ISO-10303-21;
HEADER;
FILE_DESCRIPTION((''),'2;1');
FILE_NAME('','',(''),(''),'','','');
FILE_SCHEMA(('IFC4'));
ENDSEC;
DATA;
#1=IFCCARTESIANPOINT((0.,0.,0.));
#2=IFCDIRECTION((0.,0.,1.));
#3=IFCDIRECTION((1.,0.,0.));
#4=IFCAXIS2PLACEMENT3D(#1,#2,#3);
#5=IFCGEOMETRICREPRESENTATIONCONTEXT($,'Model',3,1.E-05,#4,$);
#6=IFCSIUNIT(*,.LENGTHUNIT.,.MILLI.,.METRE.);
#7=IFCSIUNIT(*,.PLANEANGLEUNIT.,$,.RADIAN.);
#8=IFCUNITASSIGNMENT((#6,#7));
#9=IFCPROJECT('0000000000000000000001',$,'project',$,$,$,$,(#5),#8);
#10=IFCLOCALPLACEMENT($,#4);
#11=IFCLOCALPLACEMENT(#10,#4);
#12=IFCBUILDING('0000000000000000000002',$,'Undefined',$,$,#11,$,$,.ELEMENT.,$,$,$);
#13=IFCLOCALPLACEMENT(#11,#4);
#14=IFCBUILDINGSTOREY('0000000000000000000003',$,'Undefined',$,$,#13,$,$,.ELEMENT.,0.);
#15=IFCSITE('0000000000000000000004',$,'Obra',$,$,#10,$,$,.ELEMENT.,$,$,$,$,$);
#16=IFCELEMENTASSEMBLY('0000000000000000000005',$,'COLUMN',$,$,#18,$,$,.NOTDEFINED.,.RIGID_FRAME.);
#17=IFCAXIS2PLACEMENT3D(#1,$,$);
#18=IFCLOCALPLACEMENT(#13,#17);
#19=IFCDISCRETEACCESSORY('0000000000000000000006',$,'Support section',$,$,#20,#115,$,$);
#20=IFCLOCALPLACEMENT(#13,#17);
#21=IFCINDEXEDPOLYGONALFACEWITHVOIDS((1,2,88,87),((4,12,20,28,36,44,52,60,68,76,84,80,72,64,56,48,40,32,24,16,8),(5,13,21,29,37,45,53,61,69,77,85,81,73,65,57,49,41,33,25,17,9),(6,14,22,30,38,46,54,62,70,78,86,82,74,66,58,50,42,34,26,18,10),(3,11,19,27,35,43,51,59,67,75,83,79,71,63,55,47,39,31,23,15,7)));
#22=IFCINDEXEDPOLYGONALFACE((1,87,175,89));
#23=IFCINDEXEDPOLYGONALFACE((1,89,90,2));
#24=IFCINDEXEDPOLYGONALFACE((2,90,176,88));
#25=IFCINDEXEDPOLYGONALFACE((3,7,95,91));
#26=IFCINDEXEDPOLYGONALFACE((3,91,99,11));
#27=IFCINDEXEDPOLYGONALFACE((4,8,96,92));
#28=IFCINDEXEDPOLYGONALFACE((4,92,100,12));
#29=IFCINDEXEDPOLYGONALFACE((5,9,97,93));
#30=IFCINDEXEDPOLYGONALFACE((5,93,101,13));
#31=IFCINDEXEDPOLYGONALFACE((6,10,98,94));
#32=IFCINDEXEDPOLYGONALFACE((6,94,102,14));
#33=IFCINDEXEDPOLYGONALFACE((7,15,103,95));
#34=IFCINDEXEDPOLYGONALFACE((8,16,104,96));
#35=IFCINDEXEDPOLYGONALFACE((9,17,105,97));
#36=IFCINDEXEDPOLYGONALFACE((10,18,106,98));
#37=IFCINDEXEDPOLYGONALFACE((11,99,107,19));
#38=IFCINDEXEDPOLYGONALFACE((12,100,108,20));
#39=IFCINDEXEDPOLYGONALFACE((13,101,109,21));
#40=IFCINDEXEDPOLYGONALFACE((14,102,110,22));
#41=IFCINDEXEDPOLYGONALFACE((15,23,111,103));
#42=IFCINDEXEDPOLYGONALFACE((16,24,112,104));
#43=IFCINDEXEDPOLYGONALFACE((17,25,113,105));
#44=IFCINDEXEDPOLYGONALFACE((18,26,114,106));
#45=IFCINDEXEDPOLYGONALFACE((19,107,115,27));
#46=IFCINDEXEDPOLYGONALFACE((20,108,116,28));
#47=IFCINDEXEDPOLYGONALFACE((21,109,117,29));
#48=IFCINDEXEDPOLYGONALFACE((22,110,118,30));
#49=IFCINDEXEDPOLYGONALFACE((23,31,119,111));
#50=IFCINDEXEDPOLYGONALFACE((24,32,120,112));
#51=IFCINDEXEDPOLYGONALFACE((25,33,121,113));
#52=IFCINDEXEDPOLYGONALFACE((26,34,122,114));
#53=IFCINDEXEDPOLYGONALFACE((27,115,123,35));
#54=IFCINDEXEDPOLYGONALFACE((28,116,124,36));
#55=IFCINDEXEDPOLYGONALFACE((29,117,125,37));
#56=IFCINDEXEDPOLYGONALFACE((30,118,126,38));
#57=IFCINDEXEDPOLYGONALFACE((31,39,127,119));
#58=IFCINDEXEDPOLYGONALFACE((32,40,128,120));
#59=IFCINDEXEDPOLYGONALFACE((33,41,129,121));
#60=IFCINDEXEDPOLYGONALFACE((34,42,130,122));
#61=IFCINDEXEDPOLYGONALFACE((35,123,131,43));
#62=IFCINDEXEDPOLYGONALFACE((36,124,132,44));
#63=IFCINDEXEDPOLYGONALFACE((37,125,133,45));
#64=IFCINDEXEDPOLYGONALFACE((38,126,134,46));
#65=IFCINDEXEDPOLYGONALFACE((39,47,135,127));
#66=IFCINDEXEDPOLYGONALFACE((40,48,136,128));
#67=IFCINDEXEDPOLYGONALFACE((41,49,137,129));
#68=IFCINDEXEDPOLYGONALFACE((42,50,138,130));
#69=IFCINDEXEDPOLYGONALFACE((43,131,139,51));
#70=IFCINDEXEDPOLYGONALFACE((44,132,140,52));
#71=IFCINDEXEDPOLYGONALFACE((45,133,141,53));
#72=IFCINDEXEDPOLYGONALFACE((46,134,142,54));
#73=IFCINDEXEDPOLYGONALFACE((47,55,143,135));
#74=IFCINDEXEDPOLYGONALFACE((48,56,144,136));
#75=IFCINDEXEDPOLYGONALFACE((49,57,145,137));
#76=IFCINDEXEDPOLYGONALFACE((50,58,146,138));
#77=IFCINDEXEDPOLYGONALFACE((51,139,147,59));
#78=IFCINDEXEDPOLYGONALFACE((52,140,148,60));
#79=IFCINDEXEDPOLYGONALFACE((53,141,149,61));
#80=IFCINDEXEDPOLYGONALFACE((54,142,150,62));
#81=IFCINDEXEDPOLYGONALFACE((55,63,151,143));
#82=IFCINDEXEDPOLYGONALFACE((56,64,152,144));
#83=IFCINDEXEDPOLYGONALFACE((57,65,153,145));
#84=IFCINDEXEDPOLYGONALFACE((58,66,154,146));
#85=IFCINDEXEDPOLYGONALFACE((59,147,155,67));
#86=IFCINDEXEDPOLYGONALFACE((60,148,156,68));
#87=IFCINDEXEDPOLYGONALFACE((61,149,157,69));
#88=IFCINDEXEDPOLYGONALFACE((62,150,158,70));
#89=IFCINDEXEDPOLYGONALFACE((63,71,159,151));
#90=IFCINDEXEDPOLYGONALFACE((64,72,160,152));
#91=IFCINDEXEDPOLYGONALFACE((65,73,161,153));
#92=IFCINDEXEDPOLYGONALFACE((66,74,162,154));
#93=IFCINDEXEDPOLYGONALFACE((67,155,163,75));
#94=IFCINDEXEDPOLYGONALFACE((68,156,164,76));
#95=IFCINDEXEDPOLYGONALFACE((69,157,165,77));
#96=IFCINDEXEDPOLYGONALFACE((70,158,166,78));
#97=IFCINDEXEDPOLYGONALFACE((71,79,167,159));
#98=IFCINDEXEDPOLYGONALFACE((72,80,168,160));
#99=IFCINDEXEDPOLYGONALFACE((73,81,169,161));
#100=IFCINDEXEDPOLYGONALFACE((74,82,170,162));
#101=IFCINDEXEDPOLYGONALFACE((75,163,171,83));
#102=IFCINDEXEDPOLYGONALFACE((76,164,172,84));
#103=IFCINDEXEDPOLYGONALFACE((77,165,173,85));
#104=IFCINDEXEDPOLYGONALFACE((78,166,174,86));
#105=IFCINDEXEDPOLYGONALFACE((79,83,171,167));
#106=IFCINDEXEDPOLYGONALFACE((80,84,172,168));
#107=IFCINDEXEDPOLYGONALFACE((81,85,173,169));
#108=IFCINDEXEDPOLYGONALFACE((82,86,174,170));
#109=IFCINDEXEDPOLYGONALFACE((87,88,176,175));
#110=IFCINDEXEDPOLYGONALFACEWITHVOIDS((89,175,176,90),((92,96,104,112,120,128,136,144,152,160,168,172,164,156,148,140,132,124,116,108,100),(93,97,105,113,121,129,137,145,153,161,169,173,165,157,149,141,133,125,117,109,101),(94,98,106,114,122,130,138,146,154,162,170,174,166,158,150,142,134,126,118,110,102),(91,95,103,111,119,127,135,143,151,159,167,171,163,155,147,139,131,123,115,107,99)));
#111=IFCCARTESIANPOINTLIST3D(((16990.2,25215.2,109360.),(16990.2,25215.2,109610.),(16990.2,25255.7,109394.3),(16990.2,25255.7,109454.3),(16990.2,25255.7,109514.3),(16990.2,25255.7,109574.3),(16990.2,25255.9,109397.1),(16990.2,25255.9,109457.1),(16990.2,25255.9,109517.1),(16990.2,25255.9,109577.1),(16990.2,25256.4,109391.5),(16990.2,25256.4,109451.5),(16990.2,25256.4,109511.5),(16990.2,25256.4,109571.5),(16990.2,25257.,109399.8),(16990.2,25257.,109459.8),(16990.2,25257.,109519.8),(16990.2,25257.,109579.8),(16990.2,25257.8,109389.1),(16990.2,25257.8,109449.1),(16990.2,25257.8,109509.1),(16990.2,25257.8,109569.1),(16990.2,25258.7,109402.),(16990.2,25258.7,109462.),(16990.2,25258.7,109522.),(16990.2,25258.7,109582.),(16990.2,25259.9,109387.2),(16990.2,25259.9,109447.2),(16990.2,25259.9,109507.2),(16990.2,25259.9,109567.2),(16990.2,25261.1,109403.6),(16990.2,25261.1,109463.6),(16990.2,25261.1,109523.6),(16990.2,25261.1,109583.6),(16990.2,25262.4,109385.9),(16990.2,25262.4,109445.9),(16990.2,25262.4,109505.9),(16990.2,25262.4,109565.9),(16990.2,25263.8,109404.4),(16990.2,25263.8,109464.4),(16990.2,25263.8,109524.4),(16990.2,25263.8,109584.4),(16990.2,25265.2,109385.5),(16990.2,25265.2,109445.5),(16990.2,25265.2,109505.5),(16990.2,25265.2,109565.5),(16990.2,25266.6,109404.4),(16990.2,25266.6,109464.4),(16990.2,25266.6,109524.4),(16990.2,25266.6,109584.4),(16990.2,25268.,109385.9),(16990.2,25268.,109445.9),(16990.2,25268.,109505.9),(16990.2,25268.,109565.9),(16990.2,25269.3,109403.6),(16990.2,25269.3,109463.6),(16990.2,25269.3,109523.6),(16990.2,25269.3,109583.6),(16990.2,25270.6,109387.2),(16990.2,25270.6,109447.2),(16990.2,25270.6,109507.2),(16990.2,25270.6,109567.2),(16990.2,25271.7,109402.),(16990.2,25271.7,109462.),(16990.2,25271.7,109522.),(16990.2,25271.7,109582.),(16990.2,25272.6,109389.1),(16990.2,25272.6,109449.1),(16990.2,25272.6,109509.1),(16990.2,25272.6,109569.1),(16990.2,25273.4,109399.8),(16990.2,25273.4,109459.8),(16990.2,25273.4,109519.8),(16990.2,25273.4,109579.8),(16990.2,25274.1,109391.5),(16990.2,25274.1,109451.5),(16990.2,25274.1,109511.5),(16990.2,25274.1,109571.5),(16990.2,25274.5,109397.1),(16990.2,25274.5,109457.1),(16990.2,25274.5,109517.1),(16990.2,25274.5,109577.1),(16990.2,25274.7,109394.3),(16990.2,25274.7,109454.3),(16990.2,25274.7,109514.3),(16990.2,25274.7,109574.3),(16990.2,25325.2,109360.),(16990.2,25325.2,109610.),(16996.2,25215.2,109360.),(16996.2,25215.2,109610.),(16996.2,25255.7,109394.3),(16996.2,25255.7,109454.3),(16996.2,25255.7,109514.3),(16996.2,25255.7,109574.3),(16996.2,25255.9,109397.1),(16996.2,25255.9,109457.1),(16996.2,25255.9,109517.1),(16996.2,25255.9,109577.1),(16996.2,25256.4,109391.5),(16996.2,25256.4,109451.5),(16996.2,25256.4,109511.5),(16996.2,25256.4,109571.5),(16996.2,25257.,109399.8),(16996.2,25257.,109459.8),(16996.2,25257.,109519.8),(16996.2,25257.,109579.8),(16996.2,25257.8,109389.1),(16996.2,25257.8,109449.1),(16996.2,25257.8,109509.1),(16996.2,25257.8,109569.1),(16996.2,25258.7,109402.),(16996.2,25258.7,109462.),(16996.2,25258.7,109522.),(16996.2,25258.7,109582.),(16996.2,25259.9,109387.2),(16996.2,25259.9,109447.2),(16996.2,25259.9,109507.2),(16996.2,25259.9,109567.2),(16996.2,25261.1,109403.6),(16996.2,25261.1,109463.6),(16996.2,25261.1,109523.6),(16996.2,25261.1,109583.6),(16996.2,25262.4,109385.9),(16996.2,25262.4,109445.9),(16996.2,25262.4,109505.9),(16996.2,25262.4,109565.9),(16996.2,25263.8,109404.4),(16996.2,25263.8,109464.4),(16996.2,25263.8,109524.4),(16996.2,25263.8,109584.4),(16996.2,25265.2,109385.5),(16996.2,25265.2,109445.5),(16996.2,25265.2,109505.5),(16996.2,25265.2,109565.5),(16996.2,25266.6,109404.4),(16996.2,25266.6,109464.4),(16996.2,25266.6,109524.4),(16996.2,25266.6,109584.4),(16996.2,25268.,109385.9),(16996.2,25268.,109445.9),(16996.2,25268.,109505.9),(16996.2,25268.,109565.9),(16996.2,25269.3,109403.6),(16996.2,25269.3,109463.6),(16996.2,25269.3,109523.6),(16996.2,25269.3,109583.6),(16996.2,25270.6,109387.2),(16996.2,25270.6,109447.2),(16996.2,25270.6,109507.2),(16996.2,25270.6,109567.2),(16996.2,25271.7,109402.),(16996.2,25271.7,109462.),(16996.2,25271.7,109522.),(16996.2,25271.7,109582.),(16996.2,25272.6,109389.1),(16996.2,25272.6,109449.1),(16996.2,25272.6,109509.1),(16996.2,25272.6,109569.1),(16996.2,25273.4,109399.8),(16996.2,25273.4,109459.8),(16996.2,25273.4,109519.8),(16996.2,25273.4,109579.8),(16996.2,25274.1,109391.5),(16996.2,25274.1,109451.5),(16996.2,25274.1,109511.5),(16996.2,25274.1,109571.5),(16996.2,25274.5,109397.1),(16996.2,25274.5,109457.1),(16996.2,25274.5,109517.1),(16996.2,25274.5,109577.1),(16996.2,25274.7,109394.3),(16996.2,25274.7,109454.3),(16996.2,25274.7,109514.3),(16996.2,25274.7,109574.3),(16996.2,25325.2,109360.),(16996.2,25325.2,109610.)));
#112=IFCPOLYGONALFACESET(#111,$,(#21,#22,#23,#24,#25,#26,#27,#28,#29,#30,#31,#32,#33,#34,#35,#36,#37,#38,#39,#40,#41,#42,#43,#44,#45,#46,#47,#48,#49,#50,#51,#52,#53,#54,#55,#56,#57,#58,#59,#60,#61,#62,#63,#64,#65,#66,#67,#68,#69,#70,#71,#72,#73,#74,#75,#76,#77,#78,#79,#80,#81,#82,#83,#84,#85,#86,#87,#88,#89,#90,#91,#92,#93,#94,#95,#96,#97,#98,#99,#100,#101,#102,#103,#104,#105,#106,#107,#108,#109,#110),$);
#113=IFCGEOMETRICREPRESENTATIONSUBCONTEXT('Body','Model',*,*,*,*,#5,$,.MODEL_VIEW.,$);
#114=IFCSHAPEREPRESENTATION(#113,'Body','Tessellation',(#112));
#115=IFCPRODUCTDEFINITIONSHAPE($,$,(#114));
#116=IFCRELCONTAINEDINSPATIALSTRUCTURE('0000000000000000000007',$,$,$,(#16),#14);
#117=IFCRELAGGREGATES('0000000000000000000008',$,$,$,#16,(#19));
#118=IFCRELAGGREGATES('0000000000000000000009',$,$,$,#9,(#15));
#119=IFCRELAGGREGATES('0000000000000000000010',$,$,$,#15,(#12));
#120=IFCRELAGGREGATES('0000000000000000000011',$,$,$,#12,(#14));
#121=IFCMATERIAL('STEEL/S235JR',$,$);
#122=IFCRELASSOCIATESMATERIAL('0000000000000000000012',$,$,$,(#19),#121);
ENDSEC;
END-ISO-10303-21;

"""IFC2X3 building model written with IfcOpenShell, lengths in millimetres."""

from ifc_helpers import new_model, si_unit, frame, origin_with_axes, origin_2d_with_axis, place, context, subcontext, project, spatial, rectangle, circle, extrude, source, transform, mapped, material, element, aggregate, save


model = new_model("IFC2X3")

# Units and contexts
model_context = context("Model", 3, precision=1e-05, world=origin_with_axes())
body_context = subcontext(model_context, "Body", "Model", "MODEL_VIEW")
ifc_project = project(units=[si_unit("LENGTHUNIT", "METRE", prefix="MILLI"), si_unit("PLANEANGLEUNIT", "RADIAN")], contexts=[model_context])

# Site, building, storey
site_placement = place(None, origin_with_axes())
site = spatial("IfcSite", under=ifc_project, at=site_placement, Name="Obra", CompositionType="ELEMENT")
building_placement = place(site_placement, origin_with_axes())
building = spatial("IfcBuilding", under=site, at=building_placement, Name="Undefined", CompositionType="ELEMENT")
storey_placement = place(building_placement, origin_with_axes())
storey = spatial("IfcBuildingStorey", under=building, at=storey_placement, Name="Undefined", CompositionType="ELEMENT", Elevation=0.0)

# Element assembly, discrete accessory, opening
ifc_material_1 = material(Name="STEEL/S235JR")
shared_shape_1 = source(origin_with_axes(), body_context, "Body", "SweptSolid", [
    extrude(circle(Radius=9.5, at=origin_2d_with_axis()), frame((0.0, -9.8, 0.0), z_axis=(0.0, 1.0, 0.0), x_axis=(1.0, 0.0, 0.0)), (0.0, 0.0, 1.0), 6.2),
])
assembly_1_placement = place(storey_placement, origin_with_axes())
assembly_1 = element("IfcElementAssembly", 1, at=assembly_1_placement, inside=storey, Name="COLUMN", AssemblyPlace="NOTDEFINED", PredefinedType="RIGID_FRAME")
discrete_accessory_1_placement = place(assembly_1_placement, frame((16993.2, 25270.2, 109360.0), z_axis=(0.0, 0.0, 1.0), x_axis=(0.0, 1.0, 0.0)))
discrete_accessory_1 = element("IfcDiscreteAccessory", 2, at=discrete_accessory_1_placement, material=ifc_material_1, Name="Support section", context=body_context, shape_type="SweptSolid", body=[
    extrude(rectangle(XDim=6.0, YDim=110.0, at=origin_2d_with_axis()), frame((0.0, 0.0, 250.0), z_axis=(0.0, 0.0, -1.0), x_axis=(0.0, 1.0, 0.0)), (0.0, 0.0, 1.0), 250.0),
])
opening_1_placement = place(assembly_1_placement, frame((17000.0, 25315.2, 109650.0), z_axis=(0.0, -1.0, 0.0), x_axis=(0.0, 0.0, -1.0)))
element("IfcOpeningElement", 3, at=opening_1_placement, cuts=discrete_accessory_1, ObjectType="Opening", context=body_context, shape_type="MappedRepresentation", body=[
    mapped(shared_shape_1, transform((75.0, 0.0, 50.0))),
    mapped(shared_shape_1, transform((135.0, 0.0, 50.0))),
    mapped(shared_shape_1, transform((195.0, 0.0, 50.0))),
    mapped(shared_shape_1, transform((255.0, 0.0, 50.0))),
])
aggregate(assembly_1, [discrete_accessory_1])

save(model, "model.ifc")
